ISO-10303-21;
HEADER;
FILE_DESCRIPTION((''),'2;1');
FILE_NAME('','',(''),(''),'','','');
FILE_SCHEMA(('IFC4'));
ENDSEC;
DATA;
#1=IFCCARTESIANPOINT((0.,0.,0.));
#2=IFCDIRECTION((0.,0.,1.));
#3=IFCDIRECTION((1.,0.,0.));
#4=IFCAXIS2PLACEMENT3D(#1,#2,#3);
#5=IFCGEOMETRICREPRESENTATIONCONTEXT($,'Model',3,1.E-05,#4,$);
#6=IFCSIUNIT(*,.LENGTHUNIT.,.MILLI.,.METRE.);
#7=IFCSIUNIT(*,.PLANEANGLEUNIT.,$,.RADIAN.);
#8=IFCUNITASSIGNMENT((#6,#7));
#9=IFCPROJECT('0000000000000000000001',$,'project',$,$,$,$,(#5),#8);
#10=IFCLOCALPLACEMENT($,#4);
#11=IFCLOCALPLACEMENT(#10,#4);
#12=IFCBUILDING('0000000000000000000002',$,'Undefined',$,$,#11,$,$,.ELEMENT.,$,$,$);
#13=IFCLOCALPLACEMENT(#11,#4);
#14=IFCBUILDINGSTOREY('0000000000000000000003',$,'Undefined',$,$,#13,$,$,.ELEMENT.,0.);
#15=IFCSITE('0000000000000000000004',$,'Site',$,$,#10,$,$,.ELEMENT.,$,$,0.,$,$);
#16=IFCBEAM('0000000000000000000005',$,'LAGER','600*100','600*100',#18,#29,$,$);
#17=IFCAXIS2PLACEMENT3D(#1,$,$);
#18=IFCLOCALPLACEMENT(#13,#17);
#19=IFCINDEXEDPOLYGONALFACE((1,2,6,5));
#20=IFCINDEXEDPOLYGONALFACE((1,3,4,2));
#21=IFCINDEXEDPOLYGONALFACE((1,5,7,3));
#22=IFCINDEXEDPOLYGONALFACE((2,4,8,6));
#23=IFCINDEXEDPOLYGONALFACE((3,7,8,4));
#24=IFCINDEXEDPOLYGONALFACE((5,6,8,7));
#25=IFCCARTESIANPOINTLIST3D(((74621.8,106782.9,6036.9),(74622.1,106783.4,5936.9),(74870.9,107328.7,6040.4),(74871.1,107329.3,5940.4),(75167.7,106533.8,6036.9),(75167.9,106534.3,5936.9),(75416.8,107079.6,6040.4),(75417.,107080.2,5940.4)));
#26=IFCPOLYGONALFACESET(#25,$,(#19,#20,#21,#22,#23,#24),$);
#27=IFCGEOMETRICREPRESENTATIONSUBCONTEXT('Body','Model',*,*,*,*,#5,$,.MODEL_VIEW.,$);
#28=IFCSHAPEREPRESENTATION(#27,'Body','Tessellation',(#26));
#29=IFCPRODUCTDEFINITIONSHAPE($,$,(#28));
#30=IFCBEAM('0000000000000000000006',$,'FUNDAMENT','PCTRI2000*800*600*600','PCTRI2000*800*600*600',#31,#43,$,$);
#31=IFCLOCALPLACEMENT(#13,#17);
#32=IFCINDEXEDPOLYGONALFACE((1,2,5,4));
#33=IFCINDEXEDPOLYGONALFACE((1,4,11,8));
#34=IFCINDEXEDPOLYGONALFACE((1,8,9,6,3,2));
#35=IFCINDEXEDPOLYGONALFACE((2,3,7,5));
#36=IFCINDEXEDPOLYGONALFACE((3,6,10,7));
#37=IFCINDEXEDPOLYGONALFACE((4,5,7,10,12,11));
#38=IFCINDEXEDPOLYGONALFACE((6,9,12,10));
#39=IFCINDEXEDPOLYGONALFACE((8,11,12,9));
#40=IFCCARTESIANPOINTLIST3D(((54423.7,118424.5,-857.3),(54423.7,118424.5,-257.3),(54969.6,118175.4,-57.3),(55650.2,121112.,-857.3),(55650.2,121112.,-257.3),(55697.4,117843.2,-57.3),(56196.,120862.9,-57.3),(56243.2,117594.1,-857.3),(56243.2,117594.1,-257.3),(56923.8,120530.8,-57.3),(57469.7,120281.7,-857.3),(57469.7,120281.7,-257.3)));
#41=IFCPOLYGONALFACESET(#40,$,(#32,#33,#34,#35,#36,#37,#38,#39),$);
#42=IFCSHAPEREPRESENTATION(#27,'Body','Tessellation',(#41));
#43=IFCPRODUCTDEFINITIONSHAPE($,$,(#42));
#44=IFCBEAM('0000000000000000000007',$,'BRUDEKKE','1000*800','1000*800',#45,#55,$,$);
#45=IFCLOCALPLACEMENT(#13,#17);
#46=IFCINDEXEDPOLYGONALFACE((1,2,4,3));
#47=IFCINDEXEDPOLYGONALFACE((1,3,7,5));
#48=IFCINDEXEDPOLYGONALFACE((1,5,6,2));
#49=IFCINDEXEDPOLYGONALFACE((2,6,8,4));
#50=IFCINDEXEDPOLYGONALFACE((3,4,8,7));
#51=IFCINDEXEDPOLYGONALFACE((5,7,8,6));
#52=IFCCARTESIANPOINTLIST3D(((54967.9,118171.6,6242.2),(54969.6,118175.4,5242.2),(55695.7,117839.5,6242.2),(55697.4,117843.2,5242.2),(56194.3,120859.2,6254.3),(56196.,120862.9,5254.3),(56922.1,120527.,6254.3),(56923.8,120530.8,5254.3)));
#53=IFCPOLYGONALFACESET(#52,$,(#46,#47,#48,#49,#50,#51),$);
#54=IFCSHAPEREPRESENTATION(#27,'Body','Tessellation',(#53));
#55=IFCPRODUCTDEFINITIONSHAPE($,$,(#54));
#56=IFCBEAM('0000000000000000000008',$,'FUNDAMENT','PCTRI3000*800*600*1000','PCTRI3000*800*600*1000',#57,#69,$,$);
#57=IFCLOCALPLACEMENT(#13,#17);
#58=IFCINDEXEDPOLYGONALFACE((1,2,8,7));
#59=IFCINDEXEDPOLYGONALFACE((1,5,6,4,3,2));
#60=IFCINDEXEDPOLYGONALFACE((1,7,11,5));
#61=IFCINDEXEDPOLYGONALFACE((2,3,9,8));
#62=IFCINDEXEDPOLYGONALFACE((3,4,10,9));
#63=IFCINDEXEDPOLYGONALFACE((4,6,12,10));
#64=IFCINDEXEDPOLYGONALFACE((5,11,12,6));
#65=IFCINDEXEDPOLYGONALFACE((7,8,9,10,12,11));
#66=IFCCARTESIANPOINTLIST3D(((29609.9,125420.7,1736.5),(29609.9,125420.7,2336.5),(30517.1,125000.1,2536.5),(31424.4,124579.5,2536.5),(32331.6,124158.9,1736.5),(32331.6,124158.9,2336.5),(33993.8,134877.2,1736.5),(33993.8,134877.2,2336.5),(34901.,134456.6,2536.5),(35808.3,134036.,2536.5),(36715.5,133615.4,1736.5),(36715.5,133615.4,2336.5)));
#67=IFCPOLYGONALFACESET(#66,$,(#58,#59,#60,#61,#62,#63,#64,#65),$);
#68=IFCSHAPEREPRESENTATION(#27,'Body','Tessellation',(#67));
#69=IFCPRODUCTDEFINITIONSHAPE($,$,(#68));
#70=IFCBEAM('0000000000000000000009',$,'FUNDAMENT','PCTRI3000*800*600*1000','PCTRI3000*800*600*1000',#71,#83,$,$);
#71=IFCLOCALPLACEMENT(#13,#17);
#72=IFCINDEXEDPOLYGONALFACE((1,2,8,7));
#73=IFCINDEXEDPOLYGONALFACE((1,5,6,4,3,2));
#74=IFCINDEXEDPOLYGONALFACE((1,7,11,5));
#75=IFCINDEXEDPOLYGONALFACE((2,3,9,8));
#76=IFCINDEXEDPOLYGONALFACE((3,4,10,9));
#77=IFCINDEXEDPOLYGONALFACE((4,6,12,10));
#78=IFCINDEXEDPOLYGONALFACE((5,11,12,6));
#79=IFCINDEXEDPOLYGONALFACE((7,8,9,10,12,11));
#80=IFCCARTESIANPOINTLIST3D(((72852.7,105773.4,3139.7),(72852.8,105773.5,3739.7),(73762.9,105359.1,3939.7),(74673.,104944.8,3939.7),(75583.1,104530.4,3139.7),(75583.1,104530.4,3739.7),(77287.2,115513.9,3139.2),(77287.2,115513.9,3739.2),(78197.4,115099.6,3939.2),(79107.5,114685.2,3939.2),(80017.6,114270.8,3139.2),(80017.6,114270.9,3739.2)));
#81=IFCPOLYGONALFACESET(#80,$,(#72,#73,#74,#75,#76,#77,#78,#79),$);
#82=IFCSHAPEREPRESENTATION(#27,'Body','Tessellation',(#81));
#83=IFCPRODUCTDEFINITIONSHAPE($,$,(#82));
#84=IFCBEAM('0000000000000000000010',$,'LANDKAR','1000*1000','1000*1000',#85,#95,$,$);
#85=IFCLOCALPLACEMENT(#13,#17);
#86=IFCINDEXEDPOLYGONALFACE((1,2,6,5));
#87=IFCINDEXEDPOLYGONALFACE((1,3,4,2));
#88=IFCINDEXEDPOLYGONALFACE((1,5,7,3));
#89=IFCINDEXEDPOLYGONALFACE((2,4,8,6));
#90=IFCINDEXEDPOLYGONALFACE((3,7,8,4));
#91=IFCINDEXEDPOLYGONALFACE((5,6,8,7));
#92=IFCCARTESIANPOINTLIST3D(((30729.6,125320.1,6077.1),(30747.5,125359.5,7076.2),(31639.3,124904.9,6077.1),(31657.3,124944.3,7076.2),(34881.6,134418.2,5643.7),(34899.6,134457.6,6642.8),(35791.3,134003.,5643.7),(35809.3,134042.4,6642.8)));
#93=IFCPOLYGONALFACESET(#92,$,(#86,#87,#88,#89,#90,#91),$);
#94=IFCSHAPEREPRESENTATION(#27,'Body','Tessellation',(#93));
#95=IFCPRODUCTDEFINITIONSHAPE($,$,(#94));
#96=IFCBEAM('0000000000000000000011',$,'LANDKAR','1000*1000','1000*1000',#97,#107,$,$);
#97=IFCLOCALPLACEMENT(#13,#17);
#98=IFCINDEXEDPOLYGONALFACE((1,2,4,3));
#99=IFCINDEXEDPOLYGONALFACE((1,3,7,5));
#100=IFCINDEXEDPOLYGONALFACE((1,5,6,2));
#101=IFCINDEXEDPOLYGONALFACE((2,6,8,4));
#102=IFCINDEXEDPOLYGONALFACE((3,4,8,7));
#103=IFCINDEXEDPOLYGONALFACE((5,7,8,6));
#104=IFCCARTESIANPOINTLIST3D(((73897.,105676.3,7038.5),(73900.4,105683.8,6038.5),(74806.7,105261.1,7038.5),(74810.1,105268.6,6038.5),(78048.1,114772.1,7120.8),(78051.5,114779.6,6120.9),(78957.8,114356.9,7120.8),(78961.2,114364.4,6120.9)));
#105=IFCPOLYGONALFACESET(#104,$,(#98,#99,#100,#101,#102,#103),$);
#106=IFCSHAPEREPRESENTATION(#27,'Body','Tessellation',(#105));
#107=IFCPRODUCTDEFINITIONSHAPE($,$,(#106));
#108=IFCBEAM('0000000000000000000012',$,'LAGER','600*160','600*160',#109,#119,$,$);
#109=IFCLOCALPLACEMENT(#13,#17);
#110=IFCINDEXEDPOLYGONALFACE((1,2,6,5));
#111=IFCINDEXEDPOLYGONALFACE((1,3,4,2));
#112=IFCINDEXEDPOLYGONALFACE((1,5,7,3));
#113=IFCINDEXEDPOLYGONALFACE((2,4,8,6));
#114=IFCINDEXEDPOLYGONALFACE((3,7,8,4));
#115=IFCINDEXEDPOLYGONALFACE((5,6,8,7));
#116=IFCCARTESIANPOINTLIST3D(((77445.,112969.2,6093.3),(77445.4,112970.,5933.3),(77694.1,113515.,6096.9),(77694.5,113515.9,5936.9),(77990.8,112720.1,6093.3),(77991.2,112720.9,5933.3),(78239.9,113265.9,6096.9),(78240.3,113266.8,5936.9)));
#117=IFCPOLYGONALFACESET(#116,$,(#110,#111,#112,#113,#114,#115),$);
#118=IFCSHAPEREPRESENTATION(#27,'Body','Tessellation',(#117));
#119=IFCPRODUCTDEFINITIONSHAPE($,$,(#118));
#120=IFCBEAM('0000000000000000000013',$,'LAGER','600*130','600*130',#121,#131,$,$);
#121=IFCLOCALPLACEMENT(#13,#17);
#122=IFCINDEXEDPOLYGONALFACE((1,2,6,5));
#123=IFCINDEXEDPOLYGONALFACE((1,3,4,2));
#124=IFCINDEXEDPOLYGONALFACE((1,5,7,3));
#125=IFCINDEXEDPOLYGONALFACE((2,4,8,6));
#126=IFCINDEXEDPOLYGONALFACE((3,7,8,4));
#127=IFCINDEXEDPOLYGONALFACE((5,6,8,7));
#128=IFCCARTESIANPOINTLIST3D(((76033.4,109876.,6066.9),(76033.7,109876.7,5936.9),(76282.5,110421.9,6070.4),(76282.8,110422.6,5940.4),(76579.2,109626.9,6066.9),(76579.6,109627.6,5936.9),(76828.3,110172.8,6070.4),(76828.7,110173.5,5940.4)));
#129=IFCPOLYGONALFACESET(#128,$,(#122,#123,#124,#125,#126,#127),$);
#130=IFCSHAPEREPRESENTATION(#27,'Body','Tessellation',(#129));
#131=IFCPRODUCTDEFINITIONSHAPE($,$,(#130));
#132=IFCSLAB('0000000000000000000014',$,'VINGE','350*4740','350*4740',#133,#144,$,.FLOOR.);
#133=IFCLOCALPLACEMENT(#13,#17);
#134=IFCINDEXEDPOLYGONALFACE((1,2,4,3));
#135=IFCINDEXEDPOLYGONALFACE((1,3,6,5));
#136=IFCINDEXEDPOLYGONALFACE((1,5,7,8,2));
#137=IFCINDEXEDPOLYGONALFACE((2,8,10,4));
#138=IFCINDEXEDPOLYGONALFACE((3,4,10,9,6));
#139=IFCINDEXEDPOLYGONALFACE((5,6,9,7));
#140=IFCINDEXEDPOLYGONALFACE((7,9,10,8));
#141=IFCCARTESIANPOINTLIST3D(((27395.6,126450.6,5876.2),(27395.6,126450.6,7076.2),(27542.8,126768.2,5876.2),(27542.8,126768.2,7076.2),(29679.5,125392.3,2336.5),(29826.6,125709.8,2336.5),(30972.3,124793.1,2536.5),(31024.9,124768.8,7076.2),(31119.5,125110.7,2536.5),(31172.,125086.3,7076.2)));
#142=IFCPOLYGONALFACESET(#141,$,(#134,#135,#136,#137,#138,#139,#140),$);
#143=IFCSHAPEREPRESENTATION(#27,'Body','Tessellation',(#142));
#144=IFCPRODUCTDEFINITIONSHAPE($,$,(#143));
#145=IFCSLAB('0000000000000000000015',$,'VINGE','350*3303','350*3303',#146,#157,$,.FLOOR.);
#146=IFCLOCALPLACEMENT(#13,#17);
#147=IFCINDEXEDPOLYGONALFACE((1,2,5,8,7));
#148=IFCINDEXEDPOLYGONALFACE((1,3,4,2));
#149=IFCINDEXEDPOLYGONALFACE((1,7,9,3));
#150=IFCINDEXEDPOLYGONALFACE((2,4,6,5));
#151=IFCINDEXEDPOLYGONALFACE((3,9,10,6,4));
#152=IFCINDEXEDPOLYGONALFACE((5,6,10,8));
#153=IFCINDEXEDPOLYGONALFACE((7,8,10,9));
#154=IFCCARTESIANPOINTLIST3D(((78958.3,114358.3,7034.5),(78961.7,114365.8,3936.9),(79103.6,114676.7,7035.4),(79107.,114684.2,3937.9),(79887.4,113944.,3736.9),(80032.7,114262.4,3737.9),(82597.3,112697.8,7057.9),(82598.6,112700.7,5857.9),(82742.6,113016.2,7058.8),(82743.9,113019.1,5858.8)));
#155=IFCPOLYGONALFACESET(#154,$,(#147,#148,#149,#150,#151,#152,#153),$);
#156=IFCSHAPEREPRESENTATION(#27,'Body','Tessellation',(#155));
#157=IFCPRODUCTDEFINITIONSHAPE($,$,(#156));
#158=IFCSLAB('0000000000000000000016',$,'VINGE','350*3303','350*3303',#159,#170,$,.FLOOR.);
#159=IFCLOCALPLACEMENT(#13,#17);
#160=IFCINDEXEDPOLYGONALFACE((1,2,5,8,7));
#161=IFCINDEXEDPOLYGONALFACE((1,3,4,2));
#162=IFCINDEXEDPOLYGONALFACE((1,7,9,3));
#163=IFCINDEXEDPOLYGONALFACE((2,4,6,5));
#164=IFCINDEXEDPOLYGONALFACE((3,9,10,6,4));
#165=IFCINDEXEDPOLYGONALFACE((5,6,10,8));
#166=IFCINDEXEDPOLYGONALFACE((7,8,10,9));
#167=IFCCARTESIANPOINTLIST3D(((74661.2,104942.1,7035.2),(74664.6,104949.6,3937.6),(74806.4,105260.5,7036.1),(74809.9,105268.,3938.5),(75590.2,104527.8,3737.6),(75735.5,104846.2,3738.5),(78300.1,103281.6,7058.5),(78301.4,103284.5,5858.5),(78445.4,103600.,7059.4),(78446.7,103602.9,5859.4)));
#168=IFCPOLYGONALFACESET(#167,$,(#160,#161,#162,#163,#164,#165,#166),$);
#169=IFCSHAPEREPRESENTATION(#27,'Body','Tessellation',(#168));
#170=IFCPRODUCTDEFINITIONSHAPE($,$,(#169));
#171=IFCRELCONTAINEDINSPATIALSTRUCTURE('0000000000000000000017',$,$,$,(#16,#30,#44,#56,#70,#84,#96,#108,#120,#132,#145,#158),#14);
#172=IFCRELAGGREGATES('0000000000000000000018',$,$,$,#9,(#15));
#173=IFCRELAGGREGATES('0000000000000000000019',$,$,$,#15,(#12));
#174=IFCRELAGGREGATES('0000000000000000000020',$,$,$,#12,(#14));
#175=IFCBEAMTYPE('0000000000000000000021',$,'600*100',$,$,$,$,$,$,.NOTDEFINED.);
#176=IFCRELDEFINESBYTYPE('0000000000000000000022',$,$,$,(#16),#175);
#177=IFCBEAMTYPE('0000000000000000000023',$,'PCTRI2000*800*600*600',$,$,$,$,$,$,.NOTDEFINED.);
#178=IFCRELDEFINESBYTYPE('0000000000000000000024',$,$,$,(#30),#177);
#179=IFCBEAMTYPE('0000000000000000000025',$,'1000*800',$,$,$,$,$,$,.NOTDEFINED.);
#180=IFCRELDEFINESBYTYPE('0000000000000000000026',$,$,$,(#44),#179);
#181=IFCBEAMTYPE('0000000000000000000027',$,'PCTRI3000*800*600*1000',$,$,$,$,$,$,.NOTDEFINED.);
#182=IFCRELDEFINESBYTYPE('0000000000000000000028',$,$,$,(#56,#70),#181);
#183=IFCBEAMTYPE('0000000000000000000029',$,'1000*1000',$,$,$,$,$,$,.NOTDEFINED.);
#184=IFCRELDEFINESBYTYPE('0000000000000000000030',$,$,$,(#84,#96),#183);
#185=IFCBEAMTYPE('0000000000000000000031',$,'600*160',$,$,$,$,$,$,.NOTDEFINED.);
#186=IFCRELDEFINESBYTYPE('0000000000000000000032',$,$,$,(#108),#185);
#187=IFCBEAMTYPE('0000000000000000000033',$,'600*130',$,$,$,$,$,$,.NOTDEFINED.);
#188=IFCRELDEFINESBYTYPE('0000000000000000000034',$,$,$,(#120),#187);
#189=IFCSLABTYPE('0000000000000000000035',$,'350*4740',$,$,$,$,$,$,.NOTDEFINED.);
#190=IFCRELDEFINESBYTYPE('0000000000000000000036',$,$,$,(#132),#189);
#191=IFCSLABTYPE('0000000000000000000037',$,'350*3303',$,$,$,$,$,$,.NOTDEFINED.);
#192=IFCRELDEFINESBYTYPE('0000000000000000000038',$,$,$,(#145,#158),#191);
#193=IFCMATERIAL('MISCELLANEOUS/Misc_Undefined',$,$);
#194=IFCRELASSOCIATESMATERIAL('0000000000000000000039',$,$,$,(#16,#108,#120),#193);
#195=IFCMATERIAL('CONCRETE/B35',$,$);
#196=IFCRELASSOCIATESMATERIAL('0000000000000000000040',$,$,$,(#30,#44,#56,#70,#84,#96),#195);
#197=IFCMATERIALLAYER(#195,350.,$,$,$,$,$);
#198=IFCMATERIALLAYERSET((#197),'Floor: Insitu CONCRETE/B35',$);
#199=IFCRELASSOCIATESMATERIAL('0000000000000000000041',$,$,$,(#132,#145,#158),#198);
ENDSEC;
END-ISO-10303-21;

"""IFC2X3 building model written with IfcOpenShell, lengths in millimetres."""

from ifc_helpers import new_model, si_unit, frame, frame_2d, origin_with_axes, place, context, subcontext, project, spatial, polyline, rectangle, outline, extrude, material, layer, layer_set, layer_usage, type_object, element, save


model = new_model("IFC2X3")

# Units and contexts
model_context = context("Model", 3, precision=1e-05, world=origin_with_axes())
body_context = subcontext(model_context, "Body", "Model", "MODEL_VIEW")
ifc_project = project(units=[si_unit("LENGTHUNIT", "METRE", prefix="MILLI"), si_unit("PLANEANGLEUNIT", "RADIAN")], contexts=[model_context])

# Site, building, storey
site_placement = place(None, origin_with_axes())
site = spatial("IfcSite", under=ifc_project, at=site_placement, Name="Site", CompositionType="ELEMENT", RefElevation=0.0)
building_placement = place(site_placement, origin_with_axes())
building = spatial("IfcBuilding", under=site, at=building_placement, Name="Undefined", CompositionType="ELEMENT")
storey_placement = place(building_placement, origin_with_axes())
storey = spatial("IfcBuildingStorey", under=building, at=storey_placement, Name="Undefined", CompositionType="ELEMENT", Elevation=0.0)

# Shared definitions
ifc_material_1 = material(Name="CONCRETE/B35")

# Beams
ifc_material_2 = material(Name="MISCELLANEOUS/Misc_Undefined")
beam_type_1 = type_object("IfcBeamType", Name="600*100", PredefinedType="NOTDEFINED")
beam_1_placement = place(storey_placement, frame((74894.9, 106658.6, 5986.9), z_axis=(-0.90975, 0.415157, 0.0), x_axis=(0.41515, 0.909734, 0.005889)))
element("IfcBeam", 1, at=beam_1_placement, inside=storey, type_object=beam_type_1, material=ifc_material_2, Name="LAGER", Description="600*100", ObjectType="600*100", context=body_context, shape_type="SweptSolid", body=[
    extrude(rectangle(XDim=100.0, YDim=600.0, at=frame_2d((0.0, 0.0), x_axis=(1.0, 0.0))), frame((600.0, 0.0, 0.0), z_axis=(-1.0, 0.0, 0.0), x_axis=(0.0, -1.0, 0.0)), (0.0, 0.0, 1.0), 600.0),
])
beam_type_2 = type_object("IfcBeamType", Name="PCTRI2000*800*600*600", PredefinedType="NOTDEFINED")
beam_2_placement = place(storey_placement, frame((55333.5, 118009.3, -457.3), z_axis=(0.0, 0.0, 1.0), x_axis=(0.415157, 0.90975, 0.0)))
element("IfcBeam", 2, at=beam_2_placement, inside=storey, type_object=beam_type_2, material=ifc_material_1, Name="FUNDAMENT", Description="PCTRI2000*800*600*600", ObjectType="PCTRI2000*800*600*600", context=body_context, shape_type="SweptSolid", body=[
    extrude(outline(polyline([(-400.0, 400.0), (400.0, 400.0), (1000.0, 200.0), (1000.0, -400.0), (-1000.0, -400.0), (-1000.0, 200.0), (-400.0, 400.0)])), frame((2954.2, 0.0, 0.0), z_axis=(-1.0, 0.0, 0.0), x_axis=(0.0, -1.0, 0.0)), (0.0, 0.0, 1.0), 2954.2),
])
beam_type_3 = type_object("IfcBeamType", Name="1000*800", PredefinedType="NOTDEFINED")
beam_3_placement = place(storey_placement, frame((55332.6, 118007.4, 5742.2), z_axis=(-0.001706, -0.003738, 0.999992), x_axis=(0.415154, 0.909742, 0.004109)))
element("IfcBeam", 3, at=beam_3_placement, inside=storey, type_object=beam_type_3, material=ifc_material_1, Name="BRUDEKKE", Description="1000*800", ObjectType="1000*800", context=body_context, shape_type="SweptSolid", body=[
    extrude(rectangle(XDim=800.0, YDim=1000.0, at=frame_2d((0.0, 0.0), x_axis=(1.0, 0.0))), frame((2954.2, 0.0, 0.0), z_axis=(-1.0, 0.0, 0.0), x_axis=(0.0, -1.0, 0.0)), (0.0, 0.0, 1.0), 2954.2),
])
beam_type_4 = type_object("IfcBeamType", Name="PCTRI3000*800*600*1000", PredefinedType="NOTDEFINED")
beam_4_placement = place(storey_placement, frame((30970.7, 124789.8, 2136.5), z_axis=(-0.000001, -0.000003, 1.0), x_axis=(0.420587, 0.907252, 0.000003)))
element("IfcBeam", 4, at=beam_4_placement, inside=storey, type_object=beam_type_4, material=ifc_material_1, Name="FUNDAMENT", Description="PCTRI3000*800*600*1000", ObjectType="PCTRI3000*800*600*1000", context=body_context, shape_type="SweptSolid", body=[
    extrude(outline(polyline([(-500.0, 400.0), (500.0, 400.0), (1500.0, 200.0), (1500.0, -400.0), (-1500.0, -400.0), (-1500.0, 200.0), (-500.0, 400.0)])), frame((10423.3, 0.0, 0.0), z_axis=(-1.0, 0.0, 0.0), x_axis=(0.0, -1.0, 0.0)), (0.0, 0.0, 1.0), 10423.3),
])
beam_5_placement = place(storey_placement, frame((74217.9, 105151.9, 3539.7), z_axis=(0.000019, 0.000042, 1.0), x_axis=(0.414346, 0.91012, -0.000046)))
element("IfcBeam", 5, at=beam_5_placement, inside=storey, type_object=beam_type_4, material=ifc_material_1, Name="FUNDAMENT", Description="PCTRI3000*800*600*1000", ObjectType="PCTRI3000*800*600*1000", context=body_context, shape_type="SweptSolid", body=[
    extrude(outline(polyline([(-500.0, 400.0), (500.0, 400.0), (1500.0, 200.0), (1500.0, -400.0), (-1500.0, -400.0), (-1500.0, 200.0), (-500.0, 400.0)])), frame((10702.4, 0.0, 0.0), z_axis=(-1.0, 0.0, 0.0), x_axis=(0.0, -1.0, 0.0)), (0.0, 0.0, 1.0), 10702.4),
])
beam_type_5 = type_object("IfcBeamType", Name="1000*1000", PredefinedType="NOTDEFINED")
beam_6_placement = place(storey_placement, frame((35345.4, 134230.3, 6143.3), z_axis=(0.017975, 0.039387, 0.999062), x_axis=(-0.414781, -0.90889, 0.043295)))
element("IfcBeam", 6, at=beam_6_placement, inside=storey, type_object=beam_type_5, material=ifc_material_1, Name="LANDKAR", Description="1000*1000", ObjectType="1000*1000", context=body_context, shape_type="SweptSolid", body=[
    extrude(rectangle(XDim=1000.0, YDim=1000.0, at=frame_2d((0.0, 0.0), x_axis=(1.0, 0.0))), frame((10010.1, 0.0, 0.0), z_axis=(-1.0, 0.0, 0.0), x_axis=(0.0, -1.0, 0.0)), (0.0, 0.0, 1.0), 10010.1),
])
beam_7_placement = place(storey_placement, frame((74353.6, 105472.5, 6538.5), z_axis=(-0.003421, -0.007496, 0.999966), x_axis=(0.415166, 0.909708, 0.008239)))
element("IfcBeam", 7, at=beam_7_placement, inside=storey, type_object=beam_type_5, material=ifc_material_1, Name="LANDKAR", Description="1000*1000", ObjectType="1000*1000", context=body_context, shape_type="SweptSolid", body=[
    extrude(rectangle(XDim=1000.0, YDim=1000.0, at=frame_2d((0.0, 0.0), x_axis=(1.0, 0.0))), frame((9998.6, 0.0, 0.0), z_axis=(-1.0, 0.0, 0.0), x_axis=(0.0, -1.0, 0.0)), (0.0, 0.0, 1.0), 9998.6),
])
beam_type_6 = type_object("IfcBeamType", Name="600*160", PredefinedType="NOTDEFINED")
beam_8_placement = place(storey_placement, frame((77718.1, 112845.0, 6013.3), z_axis=(-0.90975, 0.415157, 0.0), x_axis=(0.41515, 0.909734, 0.005889)))
element("IfcBeam", 8, at=beam_8_placement, inside=storey, type_object=beam_type_6, material=ifc_material_2, Name="LAGER", Description="600*160", ObjectType="600*160", context=body_context, shape_type="SweptSolid", body=[
    extrude(rectangle(XDim=160.0, YDim=600.0, at=frame_2d((0.0, 0.0), x_axis=(1.0, 0.0))), frame((600.0, 0.0, 0.0), z_axis=(-1.0, 0.0, 0.0), x_axis=(0.0, -1.0, 0.0)), (0.0, 0.0, 1.0), 600.0),
])
beam_type_7 = type_object("IfcBeamType", Name="600*130", PredefinedType="NOTDEFINED")
beam_9_placement = place(storey_placement, frame((76306.5, 109751.8, 6001.9), z_axis=(-0.90975, 0.415157, 0.0), x_axis=(0.41515, 0.909734, 0.005889)))
element("IfcBeam", 9, at=beam_9_placement, inside=storey, type_object=beam_type_7, material=ifc_material_2, Name="LAGER", Description="600*130", ObjectType="600*130", context=body_context, shape_type="SweptSolid", body=[
    extrude(rectangle(XDim=130.0, YDim=600.0, at=frame_2d((0.0, 0.0), x_axis=(1.0, 0.0))), frame((600.0, 0.0, 0.0), z_axis=(-1.0, 0.0, 0.0), x_axis=(0.0, -1.0, 0.0)), (0.0, 0.0, 1.0), 600.0),
])

# Slabs
ifc_layer_1 = layer(ifc_material_1, 350.0)
ifc_layer_set_1 = layer_set([ifc_layer_1], Name="Floor: Insitu CONCRETE/B35")
ifc_layer_usage_1 = layer_usage(ifc_layer_set_1, "AXIS3", "POSITIVE", -175.0)
slab_type_1 = type_object("IfcSlabType", Name="350*4740", PredefinedType="NOTDEFINED")
slab_1_placement = place(storey_placement, frame((31045.9, 124951.9, 2536.5), z_axis=(-0.420464, -0.907309, 0.0), x_axis=(0.011579, -0.005366, 0.999919)))
element("IfcSlab", 10, at=slab_1_placement, inside=storey, type_object=slab_type_1, material=ifc_layer_usage_1, Name="VINGE", Description="350*4740", ObjectType="350*4740", PredefinedType="FLOOR", context=body_context, shape_type="SweptSolid", body=[
    extrude(outline(polyline([(0.0, 0.0), (4540.0, 0.0), (4489.0, 3999.7), (3289.1, 3984.4), (-218.2, 1422.2), (0.0, 0.0)])), frame((0.0, 0.0, -175.0), z_axis=(0.0, 0.0, 1.0), x_axis=(1.0, 0.0, 0.0)), (0.0, 0.0, 1.0), 350.0),
])
ifc_layer_usage_2 = layer_usage(ifc_layer_set_1, "AXIS3", "POSITIVE", -175.0)
slab_type_2 = type_object("IfcSlabType", Name="350*3303", PredefinedType="NOTDEFINED")
slab_2_placement = place(storey_placement, frame((79034.4, 114525.0, 3937.4), z_axis=(-0.415122, -0.909762, -0.002659), x_axis=(0.892889, -0.406859, -0.19291)))
element("IfcSlab", 11, at=slab_2_placement, inside=storey, type_object=slab_type_2, material=ifc_layer_usage_2, Name="VINGE", Description="350*3303", ObjectType="350*3303", PredefinedType="FLOOR", context=body_context, shape_type="SweptSolid", body=[
    extrude(outline(polyline([(0.0, 0.0), (1036.7, 0.0), (3554.2, 2656.5), (3322.7, 3834.0), (-597.6, 3039.4), (0.0, 0.0)])), frame((0.0, 0.0, -175.0), z_axis=(0.0, 0.0, 1.0), x_axis=(1.0, 0.0, 0.0)), (0.0, 0.0, 1.0), 350.0),
])
ifc_layer_usage_3 = layer_usage(ifc_layer_set_1, "AXIS3", "POSITIVE", -175.0)
slab_3_placement = place(storey_placement, frame((74737.2, 105108.8, 3938.0), z_axis=(-0.415122, -0.909762, -0.002659), x_axis=(0.892889, -0.406859, -0.19291)))
element("IfcSlab", 12, at=slab_3_placement, inside=storey, type_object=slab_type_2, material=ifc_layer_usage_3, Name="VINGE", Description="350*3303", ObjectType="350*3303", PredefinedType="FLOOR", context=body_context, shape_type="SweptSolid", body=[
    extrude(outline(polyline([(0.0, 0.0), (1036.7, 0.0), (3554.2, 2656.5), (3322.7, 3834.0), (-597.6, 3039.4), (0.0, 0.0)])), frame((0.0, 0.0, -175.0), z_axis=(0.0, 0.0, 1.0), x_axis=(1.0, 0.0, 0.0)), (0.0, 0.0, 1.0), 350.0),
])

save(model, "model.ifc")
